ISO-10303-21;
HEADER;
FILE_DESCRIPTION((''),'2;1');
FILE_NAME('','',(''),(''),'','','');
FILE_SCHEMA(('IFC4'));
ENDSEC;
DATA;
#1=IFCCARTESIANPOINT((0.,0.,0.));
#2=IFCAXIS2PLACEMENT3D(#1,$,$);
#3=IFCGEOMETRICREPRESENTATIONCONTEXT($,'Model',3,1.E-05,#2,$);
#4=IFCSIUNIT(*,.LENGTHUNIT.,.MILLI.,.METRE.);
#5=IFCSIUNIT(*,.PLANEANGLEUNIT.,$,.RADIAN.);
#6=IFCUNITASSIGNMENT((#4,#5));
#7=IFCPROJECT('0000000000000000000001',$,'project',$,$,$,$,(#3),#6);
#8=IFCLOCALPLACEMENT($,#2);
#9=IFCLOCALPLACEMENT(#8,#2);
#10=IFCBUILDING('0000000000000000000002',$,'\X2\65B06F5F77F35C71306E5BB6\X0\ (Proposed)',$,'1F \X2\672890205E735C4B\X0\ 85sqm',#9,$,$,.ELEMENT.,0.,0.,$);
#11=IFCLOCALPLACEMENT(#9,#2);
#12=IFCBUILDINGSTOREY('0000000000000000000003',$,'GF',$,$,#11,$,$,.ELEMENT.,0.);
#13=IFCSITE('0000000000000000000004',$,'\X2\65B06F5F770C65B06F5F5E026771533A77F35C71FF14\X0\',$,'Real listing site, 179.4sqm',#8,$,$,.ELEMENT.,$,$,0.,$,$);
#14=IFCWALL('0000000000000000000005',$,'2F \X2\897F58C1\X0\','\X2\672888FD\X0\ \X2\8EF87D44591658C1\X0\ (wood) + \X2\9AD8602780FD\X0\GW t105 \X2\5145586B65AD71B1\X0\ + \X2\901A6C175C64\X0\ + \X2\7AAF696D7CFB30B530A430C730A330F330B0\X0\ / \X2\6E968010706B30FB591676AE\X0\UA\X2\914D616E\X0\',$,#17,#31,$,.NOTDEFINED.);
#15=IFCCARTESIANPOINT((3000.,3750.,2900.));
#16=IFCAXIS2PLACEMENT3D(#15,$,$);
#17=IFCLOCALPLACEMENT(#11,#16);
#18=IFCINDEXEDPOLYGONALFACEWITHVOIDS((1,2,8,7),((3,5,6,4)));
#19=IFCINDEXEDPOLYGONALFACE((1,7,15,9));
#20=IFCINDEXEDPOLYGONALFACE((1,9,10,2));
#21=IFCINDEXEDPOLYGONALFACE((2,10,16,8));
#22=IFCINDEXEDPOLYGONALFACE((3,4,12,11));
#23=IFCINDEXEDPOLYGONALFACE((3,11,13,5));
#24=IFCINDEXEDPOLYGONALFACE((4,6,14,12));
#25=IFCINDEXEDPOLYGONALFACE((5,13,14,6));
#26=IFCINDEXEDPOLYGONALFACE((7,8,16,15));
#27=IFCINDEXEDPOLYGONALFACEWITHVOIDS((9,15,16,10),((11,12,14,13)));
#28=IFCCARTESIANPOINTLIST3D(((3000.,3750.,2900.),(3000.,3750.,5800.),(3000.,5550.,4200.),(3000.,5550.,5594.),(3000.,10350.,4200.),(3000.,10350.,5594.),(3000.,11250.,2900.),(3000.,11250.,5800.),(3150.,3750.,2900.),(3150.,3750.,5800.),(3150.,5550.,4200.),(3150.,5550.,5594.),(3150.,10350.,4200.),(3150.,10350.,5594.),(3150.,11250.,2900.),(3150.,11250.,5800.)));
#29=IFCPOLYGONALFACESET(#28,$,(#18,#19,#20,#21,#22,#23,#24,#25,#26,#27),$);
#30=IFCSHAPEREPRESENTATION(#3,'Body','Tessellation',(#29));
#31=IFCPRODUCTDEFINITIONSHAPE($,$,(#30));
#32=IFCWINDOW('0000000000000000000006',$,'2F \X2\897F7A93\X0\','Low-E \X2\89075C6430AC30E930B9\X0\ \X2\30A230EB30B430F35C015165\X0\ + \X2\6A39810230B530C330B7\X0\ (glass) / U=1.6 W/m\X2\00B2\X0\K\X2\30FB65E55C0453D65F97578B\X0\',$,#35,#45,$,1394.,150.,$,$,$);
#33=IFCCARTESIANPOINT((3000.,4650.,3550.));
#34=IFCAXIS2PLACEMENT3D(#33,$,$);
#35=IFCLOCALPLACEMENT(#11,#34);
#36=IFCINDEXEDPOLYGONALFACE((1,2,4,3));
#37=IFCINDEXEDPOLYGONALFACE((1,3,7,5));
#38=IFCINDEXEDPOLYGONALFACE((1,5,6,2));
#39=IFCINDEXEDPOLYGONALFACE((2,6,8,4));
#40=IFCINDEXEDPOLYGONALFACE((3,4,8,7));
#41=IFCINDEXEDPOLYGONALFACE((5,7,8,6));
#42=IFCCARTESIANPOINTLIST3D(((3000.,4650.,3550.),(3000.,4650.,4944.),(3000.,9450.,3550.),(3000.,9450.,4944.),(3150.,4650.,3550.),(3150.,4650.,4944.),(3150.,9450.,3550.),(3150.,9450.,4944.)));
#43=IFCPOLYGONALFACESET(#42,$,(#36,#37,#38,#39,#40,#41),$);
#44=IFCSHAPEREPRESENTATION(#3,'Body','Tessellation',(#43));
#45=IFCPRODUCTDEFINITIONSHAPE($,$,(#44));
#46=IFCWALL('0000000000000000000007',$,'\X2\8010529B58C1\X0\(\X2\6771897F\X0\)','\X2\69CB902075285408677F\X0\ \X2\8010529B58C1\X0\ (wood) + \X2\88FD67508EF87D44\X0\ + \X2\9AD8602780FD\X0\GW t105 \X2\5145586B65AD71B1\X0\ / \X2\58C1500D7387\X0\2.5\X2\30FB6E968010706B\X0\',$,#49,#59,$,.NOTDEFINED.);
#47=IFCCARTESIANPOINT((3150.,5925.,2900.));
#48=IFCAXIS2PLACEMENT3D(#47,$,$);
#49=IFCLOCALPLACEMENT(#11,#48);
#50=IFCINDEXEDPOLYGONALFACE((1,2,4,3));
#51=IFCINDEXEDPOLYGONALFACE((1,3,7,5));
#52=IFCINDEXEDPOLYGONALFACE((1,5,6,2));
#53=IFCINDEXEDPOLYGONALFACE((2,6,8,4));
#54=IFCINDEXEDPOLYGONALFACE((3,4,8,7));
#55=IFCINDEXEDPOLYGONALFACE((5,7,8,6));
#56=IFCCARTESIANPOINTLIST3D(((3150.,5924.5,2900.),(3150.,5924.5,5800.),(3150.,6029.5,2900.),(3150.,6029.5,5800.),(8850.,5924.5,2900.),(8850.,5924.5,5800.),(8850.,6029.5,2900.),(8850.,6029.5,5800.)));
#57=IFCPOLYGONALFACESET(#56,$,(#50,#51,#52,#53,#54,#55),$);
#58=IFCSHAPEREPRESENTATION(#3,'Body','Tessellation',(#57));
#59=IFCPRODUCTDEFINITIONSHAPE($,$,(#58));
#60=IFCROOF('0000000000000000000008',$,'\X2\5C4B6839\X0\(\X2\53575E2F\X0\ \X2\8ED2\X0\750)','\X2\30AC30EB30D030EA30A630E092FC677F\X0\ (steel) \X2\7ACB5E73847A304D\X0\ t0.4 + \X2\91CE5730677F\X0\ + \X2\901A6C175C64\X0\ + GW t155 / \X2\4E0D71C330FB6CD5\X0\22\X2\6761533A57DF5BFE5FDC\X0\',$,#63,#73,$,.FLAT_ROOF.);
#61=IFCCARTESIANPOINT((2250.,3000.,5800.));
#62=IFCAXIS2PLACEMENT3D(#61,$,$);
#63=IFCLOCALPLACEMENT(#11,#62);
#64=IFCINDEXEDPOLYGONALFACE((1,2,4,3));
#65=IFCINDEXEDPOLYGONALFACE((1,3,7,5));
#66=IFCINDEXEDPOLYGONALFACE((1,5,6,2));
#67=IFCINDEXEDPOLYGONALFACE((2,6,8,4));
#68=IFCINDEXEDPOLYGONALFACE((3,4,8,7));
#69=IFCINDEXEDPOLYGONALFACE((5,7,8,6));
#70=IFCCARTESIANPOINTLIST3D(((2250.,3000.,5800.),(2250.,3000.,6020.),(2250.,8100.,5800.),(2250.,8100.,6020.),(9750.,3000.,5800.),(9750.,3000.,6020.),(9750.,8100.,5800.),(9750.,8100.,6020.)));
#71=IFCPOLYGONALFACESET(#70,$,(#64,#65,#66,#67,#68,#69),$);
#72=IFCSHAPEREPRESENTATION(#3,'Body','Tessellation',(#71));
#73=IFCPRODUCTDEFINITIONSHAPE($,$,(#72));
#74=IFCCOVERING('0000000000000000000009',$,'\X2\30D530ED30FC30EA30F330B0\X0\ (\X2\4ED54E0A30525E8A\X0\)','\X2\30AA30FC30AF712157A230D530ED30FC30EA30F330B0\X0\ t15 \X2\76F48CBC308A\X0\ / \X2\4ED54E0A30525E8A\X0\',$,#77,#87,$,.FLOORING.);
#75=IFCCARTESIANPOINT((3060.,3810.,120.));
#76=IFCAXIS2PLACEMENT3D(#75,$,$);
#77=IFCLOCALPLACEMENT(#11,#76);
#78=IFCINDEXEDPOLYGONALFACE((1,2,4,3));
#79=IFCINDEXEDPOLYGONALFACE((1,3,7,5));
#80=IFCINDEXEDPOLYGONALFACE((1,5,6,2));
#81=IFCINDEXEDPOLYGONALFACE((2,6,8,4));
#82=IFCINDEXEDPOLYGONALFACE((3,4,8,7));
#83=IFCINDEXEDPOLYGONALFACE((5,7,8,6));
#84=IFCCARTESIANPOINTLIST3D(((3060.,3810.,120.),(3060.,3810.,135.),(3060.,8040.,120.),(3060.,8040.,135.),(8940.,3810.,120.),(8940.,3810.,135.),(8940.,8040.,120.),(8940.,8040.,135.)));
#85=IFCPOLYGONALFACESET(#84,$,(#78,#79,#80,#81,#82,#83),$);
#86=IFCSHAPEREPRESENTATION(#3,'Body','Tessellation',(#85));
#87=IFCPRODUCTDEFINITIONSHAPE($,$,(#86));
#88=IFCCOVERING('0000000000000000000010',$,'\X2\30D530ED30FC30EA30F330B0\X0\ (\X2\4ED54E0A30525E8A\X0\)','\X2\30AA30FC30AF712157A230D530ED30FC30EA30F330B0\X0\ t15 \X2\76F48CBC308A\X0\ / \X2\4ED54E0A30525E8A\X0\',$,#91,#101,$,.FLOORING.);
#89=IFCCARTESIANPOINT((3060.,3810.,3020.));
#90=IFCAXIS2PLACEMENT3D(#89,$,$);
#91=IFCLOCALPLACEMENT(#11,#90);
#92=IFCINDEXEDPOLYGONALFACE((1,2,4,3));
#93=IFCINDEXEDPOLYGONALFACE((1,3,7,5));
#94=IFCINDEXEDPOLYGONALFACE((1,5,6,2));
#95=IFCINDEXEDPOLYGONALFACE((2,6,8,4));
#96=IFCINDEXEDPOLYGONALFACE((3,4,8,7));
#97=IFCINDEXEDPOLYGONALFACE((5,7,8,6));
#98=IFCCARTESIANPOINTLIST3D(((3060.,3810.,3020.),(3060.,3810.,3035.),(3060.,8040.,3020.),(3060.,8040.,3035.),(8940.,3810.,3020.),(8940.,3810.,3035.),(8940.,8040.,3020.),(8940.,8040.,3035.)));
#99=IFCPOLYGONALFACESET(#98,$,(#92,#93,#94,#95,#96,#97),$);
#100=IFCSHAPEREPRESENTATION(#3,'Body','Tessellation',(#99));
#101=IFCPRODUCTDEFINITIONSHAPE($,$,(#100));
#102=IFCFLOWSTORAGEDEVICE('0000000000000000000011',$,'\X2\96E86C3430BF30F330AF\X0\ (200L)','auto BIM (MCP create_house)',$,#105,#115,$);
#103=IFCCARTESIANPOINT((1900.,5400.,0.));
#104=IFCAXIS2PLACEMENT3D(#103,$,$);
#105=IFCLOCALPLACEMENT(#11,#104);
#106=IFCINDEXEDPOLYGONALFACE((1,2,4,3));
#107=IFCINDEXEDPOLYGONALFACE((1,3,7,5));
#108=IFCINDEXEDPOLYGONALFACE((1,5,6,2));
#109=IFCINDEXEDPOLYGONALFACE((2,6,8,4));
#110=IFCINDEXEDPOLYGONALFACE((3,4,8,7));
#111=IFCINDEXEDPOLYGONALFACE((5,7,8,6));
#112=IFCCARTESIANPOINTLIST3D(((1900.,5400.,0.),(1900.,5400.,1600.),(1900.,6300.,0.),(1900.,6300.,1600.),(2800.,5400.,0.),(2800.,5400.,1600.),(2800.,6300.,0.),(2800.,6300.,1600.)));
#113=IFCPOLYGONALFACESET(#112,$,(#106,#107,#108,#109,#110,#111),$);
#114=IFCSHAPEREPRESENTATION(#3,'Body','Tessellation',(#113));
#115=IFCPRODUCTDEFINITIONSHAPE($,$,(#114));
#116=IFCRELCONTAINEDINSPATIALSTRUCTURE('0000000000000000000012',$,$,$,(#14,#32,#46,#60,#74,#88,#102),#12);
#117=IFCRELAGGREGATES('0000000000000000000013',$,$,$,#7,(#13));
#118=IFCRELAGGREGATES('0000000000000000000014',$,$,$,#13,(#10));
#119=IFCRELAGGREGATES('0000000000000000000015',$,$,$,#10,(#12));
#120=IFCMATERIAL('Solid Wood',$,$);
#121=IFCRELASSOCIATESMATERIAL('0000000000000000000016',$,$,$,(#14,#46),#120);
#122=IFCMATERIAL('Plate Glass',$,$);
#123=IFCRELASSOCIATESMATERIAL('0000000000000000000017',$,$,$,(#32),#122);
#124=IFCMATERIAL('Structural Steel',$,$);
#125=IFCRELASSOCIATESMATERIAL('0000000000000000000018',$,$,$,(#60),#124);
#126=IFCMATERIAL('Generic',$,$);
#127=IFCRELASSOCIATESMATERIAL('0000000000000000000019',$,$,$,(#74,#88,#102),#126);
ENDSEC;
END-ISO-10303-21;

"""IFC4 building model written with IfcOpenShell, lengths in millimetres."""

from ifc_helpers import new_model, si_unit, frame, frame_2d, origin, place, context, project, spatial, rectangle, extrude, material, element, fill, save


model = new_model("IFC4")

# Units and contexts
model_context = context("Model", 3, precision=1e-05, world=origin())
ifc_project = project(units=[si_unit("LENGTHUNIT", "METRE", prefix="MILLI"), si_unit("PLANEANGLEUNIT", "RADIAN")], contexts=[model_context])

# Site, building, storey
site_placement = place(None, origin())
site = spatial("IfcSite", under=ifc_project, at=site_placement, Name="新潟県新潟市東区石山４", ObjectType="Real listing site, 179.4sqm", CompositionType="ELEMENT", RefElevation=0.0)
building_placement = place(site_placement, origin())
building = spatial("IfcBuilding", under=site, at=building_placement, Name="新潟石山の家 (Proposed)", ObjectType="1F 木造平屋 85sqm", CompositionType="ELEMENT", ElevationOfRefHeight=0.0, ElevationOfTerrain=0.0)
storey_placement = place(building_placement, origin())
storey = spatial("IfcBuildingStorey", under=building, at=storey_placement, Name="GF", CompositionType="ELEMENT", Elevation=0.0)

# Shared definitions
ifc_material_1 = material(Name="Solid Wood")
ifc_material_2 = material(Name="Generic")

# Shared definitions
ifc_material_3 = material(Name="Plate Glass")

# Wall, opening, window
wall_1_placement = place(storey_placement, frame((3000.0, 3750.0, 2900.0)))
wall_1 = element("IfcWall", 1, at=wall_1_placement, inside=storey, material=ifc_material_1, Name="2F 西壁", Description="木製 軸組外壁 (wood) + 高性能GW t105 充填断熱 + 通気層 + 窯業系サイディング / 準耐火・外皮UA配慮", PredefinedType="NOTDEFINED", context=model_context, shape_type="SweptSolid", body=[
    extrude(rectangle(XDim=150.0, YDim=7500.0, at=frame_2d((75.0, 3750.0))), frame((3000.0, 3750.0, 2900.0)), (0.0, 0.0, 1.0), 2900.0),
])
opening_1_placement = place(storey_placement, frame((3000.0, 4650.0, 3550.0)))
opening_1 = element("IfcOpeningElement", 2, at=opening_1_placement, cuts=wall_1, PredefinedType="NOTDEFINED", context=model_context, shape_type="SweptSolid", body=[
    extrude(rectangle(XDim=150.0, YDim=4800.0, at=frame_2d((75.0, 2400.0))), frame((3000.0, 4650.0, 3550.0)), (0.0, 0.0, 1.0), 1394.0),
])
window_1_placement = place(storey_placement, frame((3000.0, 4650.0, 3550.0)))
window_1 = element("IfcWindow", 3, at=window_1_placement, inside=storey, material=ifc_material_3, Name="2F 西窓", Description="Low-E 複層ガラス アルゴン封入 + 樹脂サッシ (glass) / U=1.6 W/m²K・日射取得型", OverallHeight=1394.0, OverallWidth=150.0, context=model_context, shape_type="SweptSolid", body=[
    extrude(rectangle(XDim=150.0, YDim=4800.0, at=frame_2d((75.0, 2400.0))), frame((3000.0, 4650.0, 3550.0)), (0.0, 0.0, 1.0), 1394.0),
])
fill(opening_1, window_1)

# Wall
wall_2_placement = place(storey_placement, frame((3150.0, 5925.0, 2900.0)))
element("IfcWall", 4, at=wall_2_placement, inside=storey, material=ifc_material_1, Name="耐力壁(東西)", Description="構造用合板 耐力壁 (wood) + 製材軸組 + 高性能GW t105 充填断熱 / 壁倍率2.5・準耐火", PredefinedType="NOTDEFINED", context=model_context, shape_type="SweptSolid", body=[
    extrude(rectangle(XDim=5700.0, YDim=105.0, at=frame_2d((2850.0, 52.0))), frame((3150.0, 5925.0, 2900.0)), (0.0, 0.0, 1.0), 2900.0),
])

# Roof
ifc_material_4 = material(Name="Structural Steel")
for number, where, name in (
    (5, (2250.0, 3000.0, 5800.0), "屋根(南帯 軒750)"),
):
    element("IfcRoof", number, at=place(storey_placement, frame(where)), inside=storey, material=ifc_material_4, Name=name, Description="ガルバリウム鋼板 (steel) 立平葺き t0.4 + 野地板 + 通気層 + GW t155 / 不燃・法22条区域対応", PredefinedType="FLAT_ROOF", context=model_context, shape_type="SweptSolid", body=[
        extrude(rectangle(XDim=7500.0, YDim=5100.0, at=frame_2d((3750.0, 2550.0))), frame((2250.0, 3000.0, 5800.0)), (0.0, 0.0, 1.0), 220.0),
    ])

# Coverings
covering_1_placement = place(storey_placement, frame((3060.0, 3810.0, 120.0)))
element("IfcCovering", 6, at=covering_1_placement, inside=storey, material=ifc_material_2, Name="フローリング (仕上げ床)", Description="オーク無垢フローリング t15 直貼り / 仕上げ床", PredefinedType="FLOORING", context=model_context, shape_type="SweptSolid", body=[
    extrude(rectangle(XDim=5880.0, YDim=4230.0, at=frame_2d((2940.0, 2115.0))), frame((3060.0, 3810.0, 120.0)), (0.0, 0.0, 1.0), 15.0),
])
covering_2_placement = place(storey_placement, frame((3060.0, 3810.0, 3020.0)))
element("IfcCovering", 7, at=covering_2_placement, inside=storey, material=ifc_material_2, Name="フローリング (仕上げ床)", Description="オーク無垢フローリング t15 直貼り / 仕上げ床", PredefinedType="FLOORING", context=model_context, shape_type="SweptSolid", body=[
    extrude(rectangle(XDim=5880.0, YDim=4230.0, at=frame_2d((2940.0, 2115.0))), frame((3060.0, 3810.0, 3020.0)), (0.0, 0.0, 1.0), 15.0),
])

# Flow storage device
flow_storage_device_placement = place(storey_placement, frame((1900.0, 5400.0, 0.0)))
element("IfcFlowStorageDevice", 8, at=flow_storage_device_placement, inside=storey, material=ifc_material_2, Name="雨水タンク (200L)", Description="auto BIM (MCP create_house)", context=model_context, shape_type="SweptSolid", body=[
    extrude(rectangle(XDim=900.0, YDim=900.0, at=frame_2d((450.0, 450.0))), frame((1900.0, 5400.0, 0.0)), (0.0, 0.0, 1.0), 1600.0),
])

save(model, "model.ifc")
